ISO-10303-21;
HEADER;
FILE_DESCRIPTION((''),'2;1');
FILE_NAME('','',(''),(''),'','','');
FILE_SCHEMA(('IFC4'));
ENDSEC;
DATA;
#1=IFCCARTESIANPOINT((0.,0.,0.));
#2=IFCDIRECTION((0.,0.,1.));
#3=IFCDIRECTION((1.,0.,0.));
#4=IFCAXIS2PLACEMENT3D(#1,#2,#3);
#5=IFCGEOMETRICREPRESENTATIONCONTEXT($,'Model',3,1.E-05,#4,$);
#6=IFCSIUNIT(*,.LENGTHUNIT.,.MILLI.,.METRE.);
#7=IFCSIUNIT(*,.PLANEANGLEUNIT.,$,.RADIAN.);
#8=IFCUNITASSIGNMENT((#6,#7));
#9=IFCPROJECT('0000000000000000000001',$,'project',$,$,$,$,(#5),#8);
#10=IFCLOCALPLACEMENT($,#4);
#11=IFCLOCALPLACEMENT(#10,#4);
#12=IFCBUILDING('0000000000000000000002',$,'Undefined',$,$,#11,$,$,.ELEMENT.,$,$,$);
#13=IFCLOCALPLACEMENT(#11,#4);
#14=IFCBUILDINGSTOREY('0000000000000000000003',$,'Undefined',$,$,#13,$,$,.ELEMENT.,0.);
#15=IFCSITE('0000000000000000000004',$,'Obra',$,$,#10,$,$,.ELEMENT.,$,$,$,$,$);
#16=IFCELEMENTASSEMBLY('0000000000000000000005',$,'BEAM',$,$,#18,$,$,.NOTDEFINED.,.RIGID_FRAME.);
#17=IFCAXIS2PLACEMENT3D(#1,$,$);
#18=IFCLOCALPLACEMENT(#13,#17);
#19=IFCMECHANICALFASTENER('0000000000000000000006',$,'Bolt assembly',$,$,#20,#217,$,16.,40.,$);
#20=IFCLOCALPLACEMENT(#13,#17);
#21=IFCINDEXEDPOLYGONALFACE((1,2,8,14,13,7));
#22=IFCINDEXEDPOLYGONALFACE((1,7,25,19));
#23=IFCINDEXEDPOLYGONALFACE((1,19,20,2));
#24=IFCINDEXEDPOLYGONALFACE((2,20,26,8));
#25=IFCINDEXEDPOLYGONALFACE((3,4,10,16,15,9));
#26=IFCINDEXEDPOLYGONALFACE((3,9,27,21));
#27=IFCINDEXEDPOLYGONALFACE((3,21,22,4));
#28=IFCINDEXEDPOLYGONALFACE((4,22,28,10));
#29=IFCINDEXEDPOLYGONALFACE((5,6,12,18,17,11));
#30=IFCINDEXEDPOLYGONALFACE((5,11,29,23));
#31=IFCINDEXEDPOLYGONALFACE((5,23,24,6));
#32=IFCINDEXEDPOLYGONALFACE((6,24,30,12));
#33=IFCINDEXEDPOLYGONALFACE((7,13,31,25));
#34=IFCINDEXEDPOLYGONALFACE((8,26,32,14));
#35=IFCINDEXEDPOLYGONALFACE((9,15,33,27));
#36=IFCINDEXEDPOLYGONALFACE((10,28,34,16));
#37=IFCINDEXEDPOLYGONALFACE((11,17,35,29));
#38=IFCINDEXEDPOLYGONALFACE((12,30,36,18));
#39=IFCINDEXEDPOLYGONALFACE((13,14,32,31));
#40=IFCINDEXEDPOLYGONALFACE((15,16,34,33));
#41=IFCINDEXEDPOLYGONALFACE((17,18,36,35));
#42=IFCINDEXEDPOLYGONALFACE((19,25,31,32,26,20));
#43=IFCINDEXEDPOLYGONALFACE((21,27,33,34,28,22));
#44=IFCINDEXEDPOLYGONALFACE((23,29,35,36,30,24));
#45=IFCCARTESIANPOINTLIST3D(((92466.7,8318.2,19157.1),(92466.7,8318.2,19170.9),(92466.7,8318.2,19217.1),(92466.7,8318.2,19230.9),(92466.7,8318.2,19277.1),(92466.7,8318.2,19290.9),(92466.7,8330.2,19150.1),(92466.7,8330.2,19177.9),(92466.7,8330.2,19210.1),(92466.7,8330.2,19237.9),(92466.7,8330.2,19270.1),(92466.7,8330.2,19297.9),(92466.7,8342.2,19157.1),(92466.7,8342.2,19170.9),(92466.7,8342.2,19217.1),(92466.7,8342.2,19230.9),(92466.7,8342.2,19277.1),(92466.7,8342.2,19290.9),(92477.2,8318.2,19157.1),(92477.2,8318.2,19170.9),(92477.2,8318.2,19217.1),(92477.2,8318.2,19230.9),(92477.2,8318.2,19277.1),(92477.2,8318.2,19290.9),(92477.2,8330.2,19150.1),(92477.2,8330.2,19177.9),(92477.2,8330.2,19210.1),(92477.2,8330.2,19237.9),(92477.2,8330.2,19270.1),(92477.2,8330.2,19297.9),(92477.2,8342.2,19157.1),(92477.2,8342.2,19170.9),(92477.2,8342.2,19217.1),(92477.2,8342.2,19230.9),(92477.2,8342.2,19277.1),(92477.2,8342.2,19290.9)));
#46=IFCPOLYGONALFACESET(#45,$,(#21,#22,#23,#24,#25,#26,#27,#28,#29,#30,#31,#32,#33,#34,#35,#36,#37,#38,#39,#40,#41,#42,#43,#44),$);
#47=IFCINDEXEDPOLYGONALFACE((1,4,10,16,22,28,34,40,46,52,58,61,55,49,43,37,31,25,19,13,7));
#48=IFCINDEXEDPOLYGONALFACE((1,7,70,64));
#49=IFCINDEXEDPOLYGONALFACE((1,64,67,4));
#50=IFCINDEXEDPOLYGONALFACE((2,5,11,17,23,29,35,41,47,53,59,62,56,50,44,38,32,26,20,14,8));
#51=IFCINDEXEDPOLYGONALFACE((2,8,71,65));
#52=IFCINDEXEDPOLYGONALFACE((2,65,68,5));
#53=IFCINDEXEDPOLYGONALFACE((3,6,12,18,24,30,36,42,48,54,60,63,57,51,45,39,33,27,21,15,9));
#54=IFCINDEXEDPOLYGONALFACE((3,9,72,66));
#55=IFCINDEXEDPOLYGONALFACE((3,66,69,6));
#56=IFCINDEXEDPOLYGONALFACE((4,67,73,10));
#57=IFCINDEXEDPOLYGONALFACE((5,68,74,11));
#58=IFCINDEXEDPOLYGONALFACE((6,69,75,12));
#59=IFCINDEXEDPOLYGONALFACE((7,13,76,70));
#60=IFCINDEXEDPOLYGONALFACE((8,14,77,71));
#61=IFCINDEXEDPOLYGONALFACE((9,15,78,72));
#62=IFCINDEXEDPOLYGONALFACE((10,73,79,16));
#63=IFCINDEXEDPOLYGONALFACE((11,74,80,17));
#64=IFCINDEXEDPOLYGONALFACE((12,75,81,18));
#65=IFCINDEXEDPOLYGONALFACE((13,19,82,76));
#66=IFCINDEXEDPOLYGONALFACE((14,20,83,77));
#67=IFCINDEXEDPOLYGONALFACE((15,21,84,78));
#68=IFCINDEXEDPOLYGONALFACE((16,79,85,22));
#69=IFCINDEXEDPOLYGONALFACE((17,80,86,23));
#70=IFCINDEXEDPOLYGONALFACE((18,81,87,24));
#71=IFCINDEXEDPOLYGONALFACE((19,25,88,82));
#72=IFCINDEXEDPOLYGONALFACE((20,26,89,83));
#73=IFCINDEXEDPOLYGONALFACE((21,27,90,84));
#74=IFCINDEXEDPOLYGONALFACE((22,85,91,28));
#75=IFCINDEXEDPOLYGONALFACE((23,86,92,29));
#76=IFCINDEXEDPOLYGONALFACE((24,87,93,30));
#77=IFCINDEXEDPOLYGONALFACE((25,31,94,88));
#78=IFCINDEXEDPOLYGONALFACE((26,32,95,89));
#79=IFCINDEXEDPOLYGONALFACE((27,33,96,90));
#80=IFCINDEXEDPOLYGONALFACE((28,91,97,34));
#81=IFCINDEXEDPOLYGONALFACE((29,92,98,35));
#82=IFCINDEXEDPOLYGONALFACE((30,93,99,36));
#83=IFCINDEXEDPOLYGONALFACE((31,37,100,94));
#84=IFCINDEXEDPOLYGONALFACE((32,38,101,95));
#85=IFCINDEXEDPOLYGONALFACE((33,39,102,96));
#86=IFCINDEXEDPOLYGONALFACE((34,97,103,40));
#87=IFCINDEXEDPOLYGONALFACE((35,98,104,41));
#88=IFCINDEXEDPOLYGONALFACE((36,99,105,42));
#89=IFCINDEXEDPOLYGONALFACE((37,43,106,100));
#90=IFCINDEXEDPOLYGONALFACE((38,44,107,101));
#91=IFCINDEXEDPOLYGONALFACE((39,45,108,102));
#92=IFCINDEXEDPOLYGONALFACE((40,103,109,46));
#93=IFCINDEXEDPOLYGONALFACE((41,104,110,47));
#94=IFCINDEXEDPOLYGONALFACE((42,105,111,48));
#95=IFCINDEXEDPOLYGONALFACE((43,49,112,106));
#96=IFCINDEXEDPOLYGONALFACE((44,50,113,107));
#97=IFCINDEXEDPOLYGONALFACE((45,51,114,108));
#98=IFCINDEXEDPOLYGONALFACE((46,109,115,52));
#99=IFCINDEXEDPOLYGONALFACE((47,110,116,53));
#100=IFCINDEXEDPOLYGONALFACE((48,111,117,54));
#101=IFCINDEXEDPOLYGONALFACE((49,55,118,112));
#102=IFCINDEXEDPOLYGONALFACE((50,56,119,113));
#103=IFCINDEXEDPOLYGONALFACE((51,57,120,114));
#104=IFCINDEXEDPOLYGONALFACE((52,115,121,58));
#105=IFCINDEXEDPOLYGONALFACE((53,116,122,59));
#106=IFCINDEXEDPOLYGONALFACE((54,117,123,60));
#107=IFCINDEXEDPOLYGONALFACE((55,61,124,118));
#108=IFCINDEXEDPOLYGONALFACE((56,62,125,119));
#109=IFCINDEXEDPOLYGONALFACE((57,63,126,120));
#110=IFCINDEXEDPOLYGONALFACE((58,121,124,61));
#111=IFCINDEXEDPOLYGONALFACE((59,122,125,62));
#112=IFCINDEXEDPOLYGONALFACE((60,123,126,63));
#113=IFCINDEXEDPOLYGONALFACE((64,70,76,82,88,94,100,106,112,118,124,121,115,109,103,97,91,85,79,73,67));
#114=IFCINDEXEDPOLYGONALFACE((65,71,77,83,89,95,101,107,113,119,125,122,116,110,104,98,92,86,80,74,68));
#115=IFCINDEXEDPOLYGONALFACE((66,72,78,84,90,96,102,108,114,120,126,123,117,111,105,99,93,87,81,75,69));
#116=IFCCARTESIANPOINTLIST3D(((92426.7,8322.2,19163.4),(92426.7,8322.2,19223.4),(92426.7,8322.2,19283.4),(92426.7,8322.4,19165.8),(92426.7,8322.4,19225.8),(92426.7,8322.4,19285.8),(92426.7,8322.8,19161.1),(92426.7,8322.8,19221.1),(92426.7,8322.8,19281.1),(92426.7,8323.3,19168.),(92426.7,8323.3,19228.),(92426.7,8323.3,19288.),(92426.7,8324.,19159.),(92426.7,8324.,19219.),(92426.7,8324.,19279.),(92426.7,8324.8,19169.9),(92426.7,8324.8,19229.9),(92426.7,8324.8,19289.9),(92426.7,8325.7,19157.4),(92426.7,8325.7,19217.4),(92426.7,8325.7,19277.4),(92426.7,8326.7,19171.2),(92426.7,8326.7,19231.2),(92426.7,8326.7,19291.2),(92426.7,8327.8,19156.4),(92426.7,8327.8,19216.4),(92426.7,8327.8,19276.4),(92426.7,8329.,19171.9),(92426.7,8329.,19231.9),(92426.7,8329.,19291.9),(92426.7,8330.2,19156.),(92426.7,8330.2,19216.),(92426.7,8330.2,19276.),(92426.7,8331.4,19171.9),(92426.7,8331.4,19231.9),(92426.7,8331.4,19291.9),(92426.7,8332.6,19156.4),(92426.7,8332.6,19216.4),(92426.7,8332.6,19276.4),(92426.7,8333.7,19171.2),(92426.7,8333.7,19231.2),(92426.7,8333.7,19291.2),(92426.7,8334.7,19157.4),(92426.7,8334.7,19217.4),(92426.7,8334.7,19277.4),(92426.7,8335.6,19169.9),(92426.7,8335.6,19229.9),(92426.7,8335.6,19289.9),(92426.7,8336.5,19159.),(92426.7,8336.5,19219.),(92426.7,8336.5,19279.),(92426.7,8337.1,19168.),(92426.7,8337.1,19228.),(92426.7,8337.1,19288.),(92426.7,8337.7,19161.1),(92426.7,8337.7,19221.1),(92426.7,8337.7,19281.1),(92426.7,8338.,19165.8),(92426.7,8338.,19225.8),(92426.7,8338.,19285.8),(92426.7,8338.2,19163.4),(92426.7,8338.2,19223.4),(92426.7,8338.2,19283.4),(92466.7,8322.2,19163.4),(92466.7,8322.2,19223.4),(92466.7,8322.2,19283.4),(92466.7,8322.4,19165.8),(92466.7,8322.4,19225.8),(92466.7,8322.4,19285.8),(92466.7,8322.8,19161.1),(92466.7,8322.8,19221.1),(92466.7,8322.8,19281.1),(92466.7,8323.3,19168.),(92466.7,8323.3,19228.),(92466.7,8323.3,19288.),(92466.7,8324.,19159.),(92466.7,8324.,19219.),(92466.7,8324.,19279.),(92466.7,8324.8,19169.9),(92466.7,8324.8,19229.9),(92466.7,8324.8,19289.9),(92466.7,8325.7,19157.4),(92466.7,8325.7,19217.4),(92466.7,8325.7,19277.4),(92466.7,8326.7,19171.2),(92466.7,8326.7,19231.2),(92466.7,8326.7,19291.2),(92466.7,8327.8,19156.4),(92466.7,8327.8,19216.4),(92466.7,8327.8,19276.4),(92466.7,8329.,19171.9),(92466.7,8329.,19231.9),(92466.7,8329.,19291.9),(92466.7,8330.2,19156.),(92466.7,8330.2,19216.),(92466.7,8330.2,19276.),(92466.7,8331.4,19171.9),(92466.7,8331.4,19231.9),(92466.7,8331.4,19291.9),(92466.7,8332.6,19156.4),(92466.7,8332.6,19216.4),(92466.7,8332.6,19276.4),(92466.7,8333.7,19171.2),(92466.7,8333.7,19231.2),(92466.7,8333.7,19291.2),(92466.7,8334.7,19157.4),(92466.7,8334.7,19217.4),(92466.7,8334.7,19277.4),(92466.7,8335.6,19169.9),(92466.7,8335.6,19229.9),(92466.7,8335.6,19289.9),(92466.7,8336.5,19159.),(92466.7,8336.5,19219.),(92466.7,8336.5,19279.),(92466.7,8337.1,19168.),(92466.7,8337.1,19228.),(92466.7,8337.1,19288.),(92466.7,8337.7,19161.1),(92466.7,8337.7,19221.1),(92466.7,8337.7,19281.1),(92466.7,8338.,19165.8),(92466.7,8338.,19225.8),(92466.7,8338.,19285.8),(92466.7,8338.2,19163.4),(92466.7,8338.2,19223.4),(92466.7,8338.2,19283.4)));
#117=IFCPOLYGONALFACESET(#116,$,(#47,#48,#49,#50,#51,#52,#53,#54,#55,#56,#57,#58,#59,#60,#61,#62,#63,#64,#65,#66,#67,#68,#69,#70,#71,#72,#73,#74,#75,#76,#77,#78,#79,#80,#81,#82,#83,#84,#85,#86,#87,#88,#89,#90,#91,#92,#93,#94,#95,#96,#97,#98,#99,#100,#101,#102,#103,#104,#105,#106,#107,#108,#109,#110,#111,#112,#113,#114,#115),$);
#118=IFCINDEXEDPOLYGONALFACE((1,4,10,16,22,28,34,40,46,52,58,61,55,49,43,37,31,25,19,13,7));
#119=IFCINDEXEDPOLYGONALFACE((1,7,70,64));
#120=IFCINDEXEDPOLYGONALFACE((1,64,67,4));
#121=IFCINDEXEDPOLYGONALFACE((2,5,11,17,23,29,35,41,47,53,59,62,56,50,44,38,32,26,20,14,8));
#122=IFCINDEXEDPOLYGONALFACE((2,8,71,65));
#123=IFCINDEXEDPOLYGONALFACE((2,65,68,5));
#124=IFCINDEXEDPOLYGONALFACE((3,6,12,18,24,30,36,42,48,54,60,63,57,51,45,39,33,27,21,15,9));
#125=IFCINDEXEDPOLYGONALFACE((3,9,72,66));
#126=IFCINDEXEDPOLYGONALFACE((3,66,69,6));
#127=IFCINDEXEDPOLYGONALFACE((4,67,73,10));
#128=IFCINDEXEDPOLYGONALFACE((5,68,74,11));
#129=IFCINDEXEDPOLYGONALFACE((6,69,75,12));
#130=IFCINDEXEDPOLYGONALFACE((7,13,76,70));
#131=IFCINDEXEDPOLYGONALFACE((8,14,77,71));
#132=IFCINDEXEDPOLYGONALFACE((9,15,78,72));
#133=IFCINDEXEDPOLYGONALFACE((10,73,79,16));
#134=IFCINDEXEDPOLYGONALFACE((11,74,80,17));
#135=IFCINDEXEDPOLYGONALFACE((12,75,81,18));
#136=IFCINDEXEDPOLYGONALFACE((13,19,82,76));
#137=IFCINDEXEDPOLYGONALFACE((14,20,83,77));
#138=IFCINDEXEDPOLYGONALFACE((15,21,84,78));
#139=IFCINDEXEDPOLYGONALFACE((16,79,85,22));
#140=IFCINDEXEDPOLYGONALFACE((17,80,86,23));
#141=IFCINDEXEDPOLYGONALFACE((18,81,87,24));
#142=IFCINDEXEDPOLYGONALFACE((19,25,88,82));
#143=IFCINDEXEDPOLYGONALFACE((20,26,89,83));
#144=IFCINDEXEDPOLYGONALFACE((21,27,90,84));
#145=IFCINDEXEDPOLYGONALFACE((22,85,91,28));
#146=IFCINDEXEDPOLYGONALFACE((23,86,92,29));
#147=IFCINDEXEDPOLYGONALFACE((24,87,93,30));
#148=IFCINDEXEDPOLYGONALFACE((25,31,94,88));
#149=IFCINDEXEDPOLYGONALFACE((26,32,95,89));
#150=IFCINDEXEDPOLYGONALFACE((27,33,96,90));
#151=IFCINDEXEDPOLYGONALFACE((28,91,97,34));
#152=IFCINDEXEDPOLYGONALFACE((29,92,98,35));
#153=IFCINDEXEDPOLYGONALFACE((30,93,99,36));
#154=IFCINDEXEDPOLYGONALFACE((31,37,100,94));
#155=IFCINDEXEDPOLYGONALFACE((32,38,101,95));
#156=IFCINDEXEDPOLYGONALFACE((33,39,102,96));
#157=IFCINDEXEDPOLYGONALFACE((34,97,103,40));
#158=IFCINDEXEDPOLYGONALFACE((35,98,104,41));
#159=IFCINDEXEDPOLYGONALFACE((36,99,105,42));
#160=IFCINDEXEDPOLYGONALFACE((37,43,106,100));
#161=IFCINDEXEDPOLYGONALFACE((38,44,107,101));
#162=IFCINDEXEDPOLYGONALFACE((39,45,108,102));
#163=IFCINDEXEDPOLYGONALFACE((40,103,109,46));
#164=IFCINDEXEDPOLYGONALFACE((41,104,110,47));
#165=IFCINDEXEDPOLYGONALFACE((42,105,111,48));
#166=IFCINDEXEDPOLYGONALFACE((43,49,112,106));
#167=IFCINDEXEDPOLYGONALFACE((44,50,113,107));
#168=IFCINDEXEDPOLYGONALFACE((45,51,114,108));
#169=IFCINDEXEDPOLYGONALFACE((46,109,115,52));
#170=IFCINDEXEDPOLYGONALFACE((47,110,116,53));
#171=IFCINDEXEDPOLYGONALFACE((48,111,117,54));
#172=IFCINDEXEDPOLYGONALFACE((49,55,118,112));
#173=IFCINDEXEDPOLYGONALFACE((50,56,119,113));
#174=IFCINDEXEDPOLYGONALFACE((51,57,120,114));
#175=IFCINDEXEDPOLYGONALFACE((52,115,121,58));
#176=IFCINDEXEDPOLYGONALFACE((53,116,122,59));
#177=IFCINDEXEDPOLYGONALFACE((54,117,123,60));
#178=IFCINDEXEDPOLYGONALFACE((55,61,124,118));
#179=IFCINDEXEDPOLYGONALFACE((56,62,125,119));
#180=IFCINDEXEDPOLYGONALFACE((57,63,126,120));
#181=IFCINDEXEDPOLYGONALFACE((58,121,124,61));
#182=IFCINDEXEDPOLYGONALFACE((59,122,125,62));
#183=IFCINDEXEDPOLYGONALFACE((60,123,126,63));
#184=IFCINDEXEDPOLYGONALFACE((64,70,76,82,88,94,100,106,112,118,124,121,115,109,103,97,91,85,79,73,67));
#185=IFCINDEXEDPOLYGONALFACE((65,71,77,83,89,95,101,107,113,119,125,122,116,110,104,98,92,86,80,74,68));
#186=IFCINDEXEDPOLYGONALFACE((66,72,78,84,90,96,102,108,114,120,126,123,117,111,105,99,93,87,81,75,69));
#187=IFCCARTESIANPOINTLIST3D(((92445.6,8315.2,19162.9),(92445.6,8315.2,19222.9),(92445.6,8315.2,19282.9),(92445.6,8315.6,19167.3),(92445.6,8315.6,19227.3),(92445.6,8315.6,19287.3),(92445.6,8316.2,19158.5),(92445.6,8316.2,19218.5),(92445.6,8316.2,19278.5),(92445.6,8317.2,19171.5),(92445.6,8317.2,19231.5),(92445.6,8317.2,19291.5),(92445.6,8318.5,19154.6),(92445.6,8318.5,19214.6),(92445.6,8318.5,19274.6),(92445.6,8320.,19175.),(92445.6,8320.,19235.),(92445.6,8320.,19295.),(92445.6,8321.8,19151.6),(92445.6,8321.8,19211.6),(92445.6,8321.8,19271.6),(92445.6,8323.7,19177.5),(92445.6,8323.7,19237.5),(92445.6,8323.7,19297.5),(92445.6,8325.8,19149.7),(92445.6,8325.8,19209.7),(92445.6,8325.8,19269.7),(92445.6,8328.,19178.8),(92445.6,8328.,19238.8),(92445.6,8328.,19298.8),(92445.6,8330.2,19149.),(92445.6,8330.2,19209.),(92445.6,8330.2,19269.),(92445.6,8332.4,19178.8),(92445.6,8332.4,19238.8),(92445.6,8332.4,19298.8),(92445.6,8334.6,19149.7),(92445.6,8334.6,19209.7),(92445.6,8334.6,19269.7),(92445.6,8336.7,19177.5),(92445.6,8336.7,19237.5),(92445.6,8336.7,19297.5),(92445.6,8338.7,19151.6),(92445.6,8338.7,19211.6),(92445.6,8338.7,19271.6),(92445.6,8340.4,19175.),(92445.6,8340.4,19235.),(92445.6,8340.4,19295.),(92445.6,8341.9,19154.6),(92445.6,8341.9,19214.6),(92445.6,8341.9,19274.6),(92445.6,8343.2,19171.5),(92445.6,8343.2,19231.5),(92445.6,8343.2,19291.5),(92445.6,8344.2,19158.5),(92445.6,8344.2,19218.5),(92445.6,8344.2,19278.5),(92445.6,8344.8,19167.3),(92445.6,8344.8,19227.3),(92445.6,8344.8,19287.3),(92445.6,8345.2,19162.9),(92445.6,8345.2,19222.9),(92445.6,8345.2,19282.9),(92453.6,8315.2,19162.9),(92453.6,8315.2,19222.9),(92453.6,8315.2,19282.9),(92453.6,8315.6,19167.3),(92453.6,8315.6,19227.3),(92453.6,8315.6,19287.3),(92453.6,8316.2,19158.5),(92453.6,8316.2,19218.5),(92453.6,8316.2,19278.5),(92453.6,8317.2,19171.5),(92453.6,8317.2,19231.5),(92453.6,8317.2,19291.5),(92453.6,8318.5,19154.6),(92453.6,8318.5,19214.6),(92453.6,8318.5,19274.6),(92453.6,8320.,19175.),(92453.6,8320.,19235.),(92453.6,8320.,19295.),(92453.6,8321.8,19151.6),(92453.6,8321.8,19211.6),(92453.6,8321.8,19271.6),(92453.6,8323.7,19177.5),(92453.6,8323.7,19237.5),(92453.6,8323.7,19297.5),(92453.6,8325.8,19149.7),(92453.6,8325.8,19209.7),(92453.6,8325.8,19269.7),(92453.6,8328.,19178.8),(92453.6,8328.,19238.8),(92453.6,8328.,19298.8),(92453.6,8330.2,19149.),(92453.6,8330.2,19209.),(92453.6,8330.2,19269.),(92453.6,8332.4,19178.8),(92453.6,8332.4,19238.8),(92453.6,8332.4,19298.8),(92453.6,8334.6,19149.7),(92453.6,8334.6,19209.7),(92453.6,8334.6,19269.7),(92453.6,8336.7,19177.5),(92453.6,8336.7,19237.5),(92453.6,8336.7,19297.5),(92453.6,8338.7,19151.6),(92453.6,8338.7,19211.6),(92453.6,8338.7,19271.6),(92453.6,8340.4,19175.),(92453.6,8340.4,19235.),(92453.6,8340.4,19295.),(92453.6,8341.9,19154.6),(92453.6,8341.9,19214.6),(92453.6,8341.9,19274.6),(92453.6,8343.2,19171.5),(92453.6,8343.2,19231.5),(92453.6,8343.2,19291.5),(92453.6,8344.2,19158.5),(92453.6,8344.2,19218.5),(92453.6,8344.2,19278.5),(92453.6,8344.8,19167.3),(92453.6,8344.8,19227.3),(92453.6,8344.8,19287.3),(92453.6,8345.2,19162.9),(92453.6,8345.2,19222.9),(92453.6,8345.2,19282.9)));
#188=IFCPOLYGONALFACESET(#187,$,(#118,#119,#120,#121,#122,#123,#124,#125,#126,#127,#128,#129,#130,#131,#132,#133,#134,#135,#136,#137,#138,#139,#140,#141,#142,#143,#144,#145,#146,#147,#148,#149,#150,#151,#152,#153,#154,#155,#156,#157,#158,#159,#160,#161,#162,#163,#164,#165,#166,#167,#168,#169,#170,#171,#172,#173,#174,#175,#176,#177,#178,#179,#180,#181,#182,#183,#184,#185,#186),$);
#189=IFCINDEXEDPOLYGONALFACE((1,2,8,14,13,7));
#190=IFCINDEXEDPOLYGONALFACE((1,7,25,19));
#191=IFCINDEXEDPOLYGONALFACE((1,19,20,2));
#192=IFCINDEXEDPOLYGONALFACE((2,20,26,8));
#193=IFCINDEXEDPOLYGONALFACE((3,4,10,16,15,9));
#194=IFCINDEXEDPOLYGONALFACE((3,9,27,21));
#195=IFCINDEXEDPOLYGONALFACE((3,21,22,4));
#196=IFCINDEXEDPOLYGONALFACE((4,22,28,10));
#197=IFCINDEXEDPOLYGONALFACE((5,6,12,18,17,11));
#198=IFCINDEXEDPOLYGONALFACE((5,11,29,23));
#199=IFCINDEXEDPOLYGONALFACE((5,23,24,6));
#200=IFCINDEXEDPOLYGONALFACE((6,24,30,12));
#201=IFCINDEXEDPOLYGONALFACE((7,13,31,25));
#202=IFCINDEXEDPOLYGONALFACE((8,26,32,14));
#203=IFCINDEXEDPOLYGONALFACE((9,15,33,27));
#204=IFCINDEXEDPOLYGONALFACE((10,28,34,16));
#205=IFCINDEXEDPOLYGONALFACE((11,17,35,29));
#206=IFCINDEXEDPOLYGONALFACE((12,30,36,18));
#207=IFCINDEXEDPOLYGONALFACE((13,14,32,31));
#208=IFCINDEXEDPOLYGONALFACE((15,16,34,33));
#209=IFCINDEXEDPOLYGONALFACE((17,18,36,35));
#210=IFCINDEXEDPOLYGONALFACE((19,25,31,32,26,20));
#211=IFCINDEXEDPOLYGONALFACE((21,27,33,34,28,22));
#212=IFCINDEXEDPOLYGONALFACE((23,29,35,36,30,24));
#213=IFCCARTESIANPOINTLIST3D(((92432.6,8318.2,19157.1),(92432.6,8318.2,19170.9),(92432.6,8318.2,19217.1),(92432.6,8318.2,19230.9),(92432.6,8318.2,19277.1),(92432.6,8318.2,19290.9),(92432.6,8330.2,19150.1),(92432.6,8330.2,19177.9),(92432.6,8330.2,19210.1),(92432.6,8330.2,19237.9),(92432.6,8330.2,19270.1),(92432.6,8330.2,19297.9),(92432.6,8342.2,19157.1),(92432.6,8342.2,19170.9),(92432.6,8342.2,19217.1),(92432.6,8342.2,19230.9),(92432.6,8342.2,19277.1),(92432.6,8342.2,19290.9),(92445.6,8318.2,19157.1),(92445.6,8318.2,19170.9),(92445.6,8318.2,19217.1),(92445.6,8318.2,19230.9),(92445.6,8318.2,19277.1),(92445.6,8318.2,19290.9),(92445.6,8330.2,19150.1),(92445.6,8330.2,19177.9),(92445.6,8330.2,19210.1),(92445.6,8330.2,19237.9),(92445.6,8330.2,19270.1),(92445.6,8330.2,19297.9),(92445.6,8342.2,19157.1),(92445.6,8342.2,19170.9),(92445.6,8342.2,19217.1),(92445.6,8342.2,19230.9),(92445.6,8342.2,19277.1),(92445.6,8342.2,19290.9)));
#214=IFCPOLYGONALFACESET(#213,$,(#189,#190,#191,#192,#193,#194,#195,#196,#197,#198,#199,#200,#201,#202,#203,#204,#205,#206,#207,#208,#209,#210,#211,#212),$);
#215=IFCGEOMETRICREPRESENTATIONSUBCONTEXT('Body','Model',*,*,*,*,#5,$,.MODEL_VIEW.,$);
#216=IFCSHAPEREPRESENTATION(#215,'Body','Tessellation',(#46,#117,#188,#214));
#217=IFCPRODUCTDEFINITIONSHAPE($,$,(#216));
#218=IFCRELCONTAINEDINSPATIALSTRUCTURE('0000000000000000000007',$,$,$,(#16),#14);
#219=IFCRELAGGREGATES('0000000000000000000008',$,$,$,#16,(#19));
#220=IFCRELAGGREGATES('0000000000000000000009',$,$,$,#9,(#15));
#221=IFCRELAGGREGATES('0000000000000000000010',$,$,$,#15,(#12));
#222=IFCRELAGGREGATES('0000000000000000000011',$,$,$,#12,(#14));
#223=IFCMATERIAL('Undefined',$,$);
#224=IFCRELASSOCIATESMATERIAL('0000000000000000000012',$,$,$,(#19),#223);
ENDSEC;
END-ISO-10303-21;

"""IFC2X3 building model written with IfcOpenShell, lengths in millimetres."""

from ifc_helpers import new_model, si_unit, frame, origin_with_axes, origin_2d_with_axis, place, context, subcontext, project, spatial, polyline, circle, outline, extrude, source, transform, mapped, material, element, aggregate, save


model = new_model("IFC2X3")

# Units and contexts
model_context = context("Model", 3, precision=1e-05, world=origin_with_axes())
body_context = subcontext(model_context, "Body", "Model", "MODEL_VIEW")
ifc_project = project(units=[si_unit("LENGTHUNIT", "METRE", prefix="MILLI"), si_unit("PLANEANGLEUNIT", "RADIAN")], contexts=[model_context])

# Site, building, storey
site_placement = place(None, origin_with_axes())
site = spatial("IfcSite", under=ifc_project, at=site_placement, Name="Obra", CompositionType="ELEMENT")
building_placement = place(site_placement, origin_with_axes())
building = spatial("IfcBuilding", under=site, at=building_placement, Name="Undefined", CompositionType="ELEMENT")
storey_placement = place(building_placement, origin_with_axes())
storey = spatial("IfcBuildingStorey", under=building, at=storey_placement, Name="Undefined", CompositionType="ELEMENT", Elevation=0.0)

# Element assembly
assembly_1_placement = place(storey_placement, origin_with_axes())
assembly_1 = element("IfcElementAssembly", 1, at=assembly_1_placement, inside=storey, Name="BEAM", AssemblyPlace="NOTDEFINED", PredefinedType="RIGID_FRAME")

# Shared definitions
ifc_material_1 = material(Name="Undefined")

# Mechanical fastener
shared_shape_1 = source(origin_with_axes(), body_context, "Body", "SweptSolid", [
    extrude(outline(polyline([(13.9, 0.0), (6.9, 12.0), (-6.9, 12.0), (-13.9, 0.0), (-6.9, -12.0), (6.9, -12.0), (13.9, 0.0)])), frame((0.0, -14.1, 0.0), z_axis=(0.0, 1.0, 0.0), x_axis=(1.0, 0.0, 0.0)), (0.0, 0.0, 1.0), 10.6),
    extrude(circle(Radius=8.0, at=origin_2d_with_axis()), frame((0.0, -3.5, 0.0), z_axis=(0.0, 1.0, 0.0), x_axis=(1.0, 0.0, 0.0)), (0.0, 0.0, 1.0), 40.0),
    extrude(circle(Radius=15.0, at=origin_2d_with_axis()), frame((0.0, 9.5, 0.0), z_axis=(0.0, 1.0, 0.0), x_axis=(1.0, 0.0, 0.0)), (0.0, 0.0, 1.0), 8.0),
    extrude(outline(polyline([(13.9, 0.0), (6.9, 12.0), (-6.9, 12.0), (-13.9, 0.0), (-6.9, -12.0), (6.9, -12.0), (13.9, 0.0)])), frame((0.0, 17.5, 0.0), z_axis=(0.0, 1.0, 0.0), x_axis=(1.0, 0.0, 0.0)), (0.0, 0.0, 1.0), 13.0),
])
mechanical_fastener_1_placement = place(assembly_1_placement, frame((92463.1, 8280.2, 19319.0), z_axis=(0.0, 1.0, 0.0), x_axis=(0.0, 0.0, -1.0)))
mechanical_fastener_1 = element("IfcMechanicalFastener", 2, at=mechanical_fastener_1_placement, material=ifc_material_1, Name="Bolt assembly", NominalDiameter=16.0, NominalLength=40.0, context=body_context, shape_type="MappedRepresentation", body=[
    mapped(shared_shape_1, transform((35.0, 0.0, 50.0))),
    mapped(shared_shape_1, transform((95.0, 0.0, 50.0))),
    mapped(shared_shape_1, transform((155.0, 0.0, 50.0))),
])
aggregate(assembly_1, [mechanical_fastener_1])

save(model, "model.ifc")
